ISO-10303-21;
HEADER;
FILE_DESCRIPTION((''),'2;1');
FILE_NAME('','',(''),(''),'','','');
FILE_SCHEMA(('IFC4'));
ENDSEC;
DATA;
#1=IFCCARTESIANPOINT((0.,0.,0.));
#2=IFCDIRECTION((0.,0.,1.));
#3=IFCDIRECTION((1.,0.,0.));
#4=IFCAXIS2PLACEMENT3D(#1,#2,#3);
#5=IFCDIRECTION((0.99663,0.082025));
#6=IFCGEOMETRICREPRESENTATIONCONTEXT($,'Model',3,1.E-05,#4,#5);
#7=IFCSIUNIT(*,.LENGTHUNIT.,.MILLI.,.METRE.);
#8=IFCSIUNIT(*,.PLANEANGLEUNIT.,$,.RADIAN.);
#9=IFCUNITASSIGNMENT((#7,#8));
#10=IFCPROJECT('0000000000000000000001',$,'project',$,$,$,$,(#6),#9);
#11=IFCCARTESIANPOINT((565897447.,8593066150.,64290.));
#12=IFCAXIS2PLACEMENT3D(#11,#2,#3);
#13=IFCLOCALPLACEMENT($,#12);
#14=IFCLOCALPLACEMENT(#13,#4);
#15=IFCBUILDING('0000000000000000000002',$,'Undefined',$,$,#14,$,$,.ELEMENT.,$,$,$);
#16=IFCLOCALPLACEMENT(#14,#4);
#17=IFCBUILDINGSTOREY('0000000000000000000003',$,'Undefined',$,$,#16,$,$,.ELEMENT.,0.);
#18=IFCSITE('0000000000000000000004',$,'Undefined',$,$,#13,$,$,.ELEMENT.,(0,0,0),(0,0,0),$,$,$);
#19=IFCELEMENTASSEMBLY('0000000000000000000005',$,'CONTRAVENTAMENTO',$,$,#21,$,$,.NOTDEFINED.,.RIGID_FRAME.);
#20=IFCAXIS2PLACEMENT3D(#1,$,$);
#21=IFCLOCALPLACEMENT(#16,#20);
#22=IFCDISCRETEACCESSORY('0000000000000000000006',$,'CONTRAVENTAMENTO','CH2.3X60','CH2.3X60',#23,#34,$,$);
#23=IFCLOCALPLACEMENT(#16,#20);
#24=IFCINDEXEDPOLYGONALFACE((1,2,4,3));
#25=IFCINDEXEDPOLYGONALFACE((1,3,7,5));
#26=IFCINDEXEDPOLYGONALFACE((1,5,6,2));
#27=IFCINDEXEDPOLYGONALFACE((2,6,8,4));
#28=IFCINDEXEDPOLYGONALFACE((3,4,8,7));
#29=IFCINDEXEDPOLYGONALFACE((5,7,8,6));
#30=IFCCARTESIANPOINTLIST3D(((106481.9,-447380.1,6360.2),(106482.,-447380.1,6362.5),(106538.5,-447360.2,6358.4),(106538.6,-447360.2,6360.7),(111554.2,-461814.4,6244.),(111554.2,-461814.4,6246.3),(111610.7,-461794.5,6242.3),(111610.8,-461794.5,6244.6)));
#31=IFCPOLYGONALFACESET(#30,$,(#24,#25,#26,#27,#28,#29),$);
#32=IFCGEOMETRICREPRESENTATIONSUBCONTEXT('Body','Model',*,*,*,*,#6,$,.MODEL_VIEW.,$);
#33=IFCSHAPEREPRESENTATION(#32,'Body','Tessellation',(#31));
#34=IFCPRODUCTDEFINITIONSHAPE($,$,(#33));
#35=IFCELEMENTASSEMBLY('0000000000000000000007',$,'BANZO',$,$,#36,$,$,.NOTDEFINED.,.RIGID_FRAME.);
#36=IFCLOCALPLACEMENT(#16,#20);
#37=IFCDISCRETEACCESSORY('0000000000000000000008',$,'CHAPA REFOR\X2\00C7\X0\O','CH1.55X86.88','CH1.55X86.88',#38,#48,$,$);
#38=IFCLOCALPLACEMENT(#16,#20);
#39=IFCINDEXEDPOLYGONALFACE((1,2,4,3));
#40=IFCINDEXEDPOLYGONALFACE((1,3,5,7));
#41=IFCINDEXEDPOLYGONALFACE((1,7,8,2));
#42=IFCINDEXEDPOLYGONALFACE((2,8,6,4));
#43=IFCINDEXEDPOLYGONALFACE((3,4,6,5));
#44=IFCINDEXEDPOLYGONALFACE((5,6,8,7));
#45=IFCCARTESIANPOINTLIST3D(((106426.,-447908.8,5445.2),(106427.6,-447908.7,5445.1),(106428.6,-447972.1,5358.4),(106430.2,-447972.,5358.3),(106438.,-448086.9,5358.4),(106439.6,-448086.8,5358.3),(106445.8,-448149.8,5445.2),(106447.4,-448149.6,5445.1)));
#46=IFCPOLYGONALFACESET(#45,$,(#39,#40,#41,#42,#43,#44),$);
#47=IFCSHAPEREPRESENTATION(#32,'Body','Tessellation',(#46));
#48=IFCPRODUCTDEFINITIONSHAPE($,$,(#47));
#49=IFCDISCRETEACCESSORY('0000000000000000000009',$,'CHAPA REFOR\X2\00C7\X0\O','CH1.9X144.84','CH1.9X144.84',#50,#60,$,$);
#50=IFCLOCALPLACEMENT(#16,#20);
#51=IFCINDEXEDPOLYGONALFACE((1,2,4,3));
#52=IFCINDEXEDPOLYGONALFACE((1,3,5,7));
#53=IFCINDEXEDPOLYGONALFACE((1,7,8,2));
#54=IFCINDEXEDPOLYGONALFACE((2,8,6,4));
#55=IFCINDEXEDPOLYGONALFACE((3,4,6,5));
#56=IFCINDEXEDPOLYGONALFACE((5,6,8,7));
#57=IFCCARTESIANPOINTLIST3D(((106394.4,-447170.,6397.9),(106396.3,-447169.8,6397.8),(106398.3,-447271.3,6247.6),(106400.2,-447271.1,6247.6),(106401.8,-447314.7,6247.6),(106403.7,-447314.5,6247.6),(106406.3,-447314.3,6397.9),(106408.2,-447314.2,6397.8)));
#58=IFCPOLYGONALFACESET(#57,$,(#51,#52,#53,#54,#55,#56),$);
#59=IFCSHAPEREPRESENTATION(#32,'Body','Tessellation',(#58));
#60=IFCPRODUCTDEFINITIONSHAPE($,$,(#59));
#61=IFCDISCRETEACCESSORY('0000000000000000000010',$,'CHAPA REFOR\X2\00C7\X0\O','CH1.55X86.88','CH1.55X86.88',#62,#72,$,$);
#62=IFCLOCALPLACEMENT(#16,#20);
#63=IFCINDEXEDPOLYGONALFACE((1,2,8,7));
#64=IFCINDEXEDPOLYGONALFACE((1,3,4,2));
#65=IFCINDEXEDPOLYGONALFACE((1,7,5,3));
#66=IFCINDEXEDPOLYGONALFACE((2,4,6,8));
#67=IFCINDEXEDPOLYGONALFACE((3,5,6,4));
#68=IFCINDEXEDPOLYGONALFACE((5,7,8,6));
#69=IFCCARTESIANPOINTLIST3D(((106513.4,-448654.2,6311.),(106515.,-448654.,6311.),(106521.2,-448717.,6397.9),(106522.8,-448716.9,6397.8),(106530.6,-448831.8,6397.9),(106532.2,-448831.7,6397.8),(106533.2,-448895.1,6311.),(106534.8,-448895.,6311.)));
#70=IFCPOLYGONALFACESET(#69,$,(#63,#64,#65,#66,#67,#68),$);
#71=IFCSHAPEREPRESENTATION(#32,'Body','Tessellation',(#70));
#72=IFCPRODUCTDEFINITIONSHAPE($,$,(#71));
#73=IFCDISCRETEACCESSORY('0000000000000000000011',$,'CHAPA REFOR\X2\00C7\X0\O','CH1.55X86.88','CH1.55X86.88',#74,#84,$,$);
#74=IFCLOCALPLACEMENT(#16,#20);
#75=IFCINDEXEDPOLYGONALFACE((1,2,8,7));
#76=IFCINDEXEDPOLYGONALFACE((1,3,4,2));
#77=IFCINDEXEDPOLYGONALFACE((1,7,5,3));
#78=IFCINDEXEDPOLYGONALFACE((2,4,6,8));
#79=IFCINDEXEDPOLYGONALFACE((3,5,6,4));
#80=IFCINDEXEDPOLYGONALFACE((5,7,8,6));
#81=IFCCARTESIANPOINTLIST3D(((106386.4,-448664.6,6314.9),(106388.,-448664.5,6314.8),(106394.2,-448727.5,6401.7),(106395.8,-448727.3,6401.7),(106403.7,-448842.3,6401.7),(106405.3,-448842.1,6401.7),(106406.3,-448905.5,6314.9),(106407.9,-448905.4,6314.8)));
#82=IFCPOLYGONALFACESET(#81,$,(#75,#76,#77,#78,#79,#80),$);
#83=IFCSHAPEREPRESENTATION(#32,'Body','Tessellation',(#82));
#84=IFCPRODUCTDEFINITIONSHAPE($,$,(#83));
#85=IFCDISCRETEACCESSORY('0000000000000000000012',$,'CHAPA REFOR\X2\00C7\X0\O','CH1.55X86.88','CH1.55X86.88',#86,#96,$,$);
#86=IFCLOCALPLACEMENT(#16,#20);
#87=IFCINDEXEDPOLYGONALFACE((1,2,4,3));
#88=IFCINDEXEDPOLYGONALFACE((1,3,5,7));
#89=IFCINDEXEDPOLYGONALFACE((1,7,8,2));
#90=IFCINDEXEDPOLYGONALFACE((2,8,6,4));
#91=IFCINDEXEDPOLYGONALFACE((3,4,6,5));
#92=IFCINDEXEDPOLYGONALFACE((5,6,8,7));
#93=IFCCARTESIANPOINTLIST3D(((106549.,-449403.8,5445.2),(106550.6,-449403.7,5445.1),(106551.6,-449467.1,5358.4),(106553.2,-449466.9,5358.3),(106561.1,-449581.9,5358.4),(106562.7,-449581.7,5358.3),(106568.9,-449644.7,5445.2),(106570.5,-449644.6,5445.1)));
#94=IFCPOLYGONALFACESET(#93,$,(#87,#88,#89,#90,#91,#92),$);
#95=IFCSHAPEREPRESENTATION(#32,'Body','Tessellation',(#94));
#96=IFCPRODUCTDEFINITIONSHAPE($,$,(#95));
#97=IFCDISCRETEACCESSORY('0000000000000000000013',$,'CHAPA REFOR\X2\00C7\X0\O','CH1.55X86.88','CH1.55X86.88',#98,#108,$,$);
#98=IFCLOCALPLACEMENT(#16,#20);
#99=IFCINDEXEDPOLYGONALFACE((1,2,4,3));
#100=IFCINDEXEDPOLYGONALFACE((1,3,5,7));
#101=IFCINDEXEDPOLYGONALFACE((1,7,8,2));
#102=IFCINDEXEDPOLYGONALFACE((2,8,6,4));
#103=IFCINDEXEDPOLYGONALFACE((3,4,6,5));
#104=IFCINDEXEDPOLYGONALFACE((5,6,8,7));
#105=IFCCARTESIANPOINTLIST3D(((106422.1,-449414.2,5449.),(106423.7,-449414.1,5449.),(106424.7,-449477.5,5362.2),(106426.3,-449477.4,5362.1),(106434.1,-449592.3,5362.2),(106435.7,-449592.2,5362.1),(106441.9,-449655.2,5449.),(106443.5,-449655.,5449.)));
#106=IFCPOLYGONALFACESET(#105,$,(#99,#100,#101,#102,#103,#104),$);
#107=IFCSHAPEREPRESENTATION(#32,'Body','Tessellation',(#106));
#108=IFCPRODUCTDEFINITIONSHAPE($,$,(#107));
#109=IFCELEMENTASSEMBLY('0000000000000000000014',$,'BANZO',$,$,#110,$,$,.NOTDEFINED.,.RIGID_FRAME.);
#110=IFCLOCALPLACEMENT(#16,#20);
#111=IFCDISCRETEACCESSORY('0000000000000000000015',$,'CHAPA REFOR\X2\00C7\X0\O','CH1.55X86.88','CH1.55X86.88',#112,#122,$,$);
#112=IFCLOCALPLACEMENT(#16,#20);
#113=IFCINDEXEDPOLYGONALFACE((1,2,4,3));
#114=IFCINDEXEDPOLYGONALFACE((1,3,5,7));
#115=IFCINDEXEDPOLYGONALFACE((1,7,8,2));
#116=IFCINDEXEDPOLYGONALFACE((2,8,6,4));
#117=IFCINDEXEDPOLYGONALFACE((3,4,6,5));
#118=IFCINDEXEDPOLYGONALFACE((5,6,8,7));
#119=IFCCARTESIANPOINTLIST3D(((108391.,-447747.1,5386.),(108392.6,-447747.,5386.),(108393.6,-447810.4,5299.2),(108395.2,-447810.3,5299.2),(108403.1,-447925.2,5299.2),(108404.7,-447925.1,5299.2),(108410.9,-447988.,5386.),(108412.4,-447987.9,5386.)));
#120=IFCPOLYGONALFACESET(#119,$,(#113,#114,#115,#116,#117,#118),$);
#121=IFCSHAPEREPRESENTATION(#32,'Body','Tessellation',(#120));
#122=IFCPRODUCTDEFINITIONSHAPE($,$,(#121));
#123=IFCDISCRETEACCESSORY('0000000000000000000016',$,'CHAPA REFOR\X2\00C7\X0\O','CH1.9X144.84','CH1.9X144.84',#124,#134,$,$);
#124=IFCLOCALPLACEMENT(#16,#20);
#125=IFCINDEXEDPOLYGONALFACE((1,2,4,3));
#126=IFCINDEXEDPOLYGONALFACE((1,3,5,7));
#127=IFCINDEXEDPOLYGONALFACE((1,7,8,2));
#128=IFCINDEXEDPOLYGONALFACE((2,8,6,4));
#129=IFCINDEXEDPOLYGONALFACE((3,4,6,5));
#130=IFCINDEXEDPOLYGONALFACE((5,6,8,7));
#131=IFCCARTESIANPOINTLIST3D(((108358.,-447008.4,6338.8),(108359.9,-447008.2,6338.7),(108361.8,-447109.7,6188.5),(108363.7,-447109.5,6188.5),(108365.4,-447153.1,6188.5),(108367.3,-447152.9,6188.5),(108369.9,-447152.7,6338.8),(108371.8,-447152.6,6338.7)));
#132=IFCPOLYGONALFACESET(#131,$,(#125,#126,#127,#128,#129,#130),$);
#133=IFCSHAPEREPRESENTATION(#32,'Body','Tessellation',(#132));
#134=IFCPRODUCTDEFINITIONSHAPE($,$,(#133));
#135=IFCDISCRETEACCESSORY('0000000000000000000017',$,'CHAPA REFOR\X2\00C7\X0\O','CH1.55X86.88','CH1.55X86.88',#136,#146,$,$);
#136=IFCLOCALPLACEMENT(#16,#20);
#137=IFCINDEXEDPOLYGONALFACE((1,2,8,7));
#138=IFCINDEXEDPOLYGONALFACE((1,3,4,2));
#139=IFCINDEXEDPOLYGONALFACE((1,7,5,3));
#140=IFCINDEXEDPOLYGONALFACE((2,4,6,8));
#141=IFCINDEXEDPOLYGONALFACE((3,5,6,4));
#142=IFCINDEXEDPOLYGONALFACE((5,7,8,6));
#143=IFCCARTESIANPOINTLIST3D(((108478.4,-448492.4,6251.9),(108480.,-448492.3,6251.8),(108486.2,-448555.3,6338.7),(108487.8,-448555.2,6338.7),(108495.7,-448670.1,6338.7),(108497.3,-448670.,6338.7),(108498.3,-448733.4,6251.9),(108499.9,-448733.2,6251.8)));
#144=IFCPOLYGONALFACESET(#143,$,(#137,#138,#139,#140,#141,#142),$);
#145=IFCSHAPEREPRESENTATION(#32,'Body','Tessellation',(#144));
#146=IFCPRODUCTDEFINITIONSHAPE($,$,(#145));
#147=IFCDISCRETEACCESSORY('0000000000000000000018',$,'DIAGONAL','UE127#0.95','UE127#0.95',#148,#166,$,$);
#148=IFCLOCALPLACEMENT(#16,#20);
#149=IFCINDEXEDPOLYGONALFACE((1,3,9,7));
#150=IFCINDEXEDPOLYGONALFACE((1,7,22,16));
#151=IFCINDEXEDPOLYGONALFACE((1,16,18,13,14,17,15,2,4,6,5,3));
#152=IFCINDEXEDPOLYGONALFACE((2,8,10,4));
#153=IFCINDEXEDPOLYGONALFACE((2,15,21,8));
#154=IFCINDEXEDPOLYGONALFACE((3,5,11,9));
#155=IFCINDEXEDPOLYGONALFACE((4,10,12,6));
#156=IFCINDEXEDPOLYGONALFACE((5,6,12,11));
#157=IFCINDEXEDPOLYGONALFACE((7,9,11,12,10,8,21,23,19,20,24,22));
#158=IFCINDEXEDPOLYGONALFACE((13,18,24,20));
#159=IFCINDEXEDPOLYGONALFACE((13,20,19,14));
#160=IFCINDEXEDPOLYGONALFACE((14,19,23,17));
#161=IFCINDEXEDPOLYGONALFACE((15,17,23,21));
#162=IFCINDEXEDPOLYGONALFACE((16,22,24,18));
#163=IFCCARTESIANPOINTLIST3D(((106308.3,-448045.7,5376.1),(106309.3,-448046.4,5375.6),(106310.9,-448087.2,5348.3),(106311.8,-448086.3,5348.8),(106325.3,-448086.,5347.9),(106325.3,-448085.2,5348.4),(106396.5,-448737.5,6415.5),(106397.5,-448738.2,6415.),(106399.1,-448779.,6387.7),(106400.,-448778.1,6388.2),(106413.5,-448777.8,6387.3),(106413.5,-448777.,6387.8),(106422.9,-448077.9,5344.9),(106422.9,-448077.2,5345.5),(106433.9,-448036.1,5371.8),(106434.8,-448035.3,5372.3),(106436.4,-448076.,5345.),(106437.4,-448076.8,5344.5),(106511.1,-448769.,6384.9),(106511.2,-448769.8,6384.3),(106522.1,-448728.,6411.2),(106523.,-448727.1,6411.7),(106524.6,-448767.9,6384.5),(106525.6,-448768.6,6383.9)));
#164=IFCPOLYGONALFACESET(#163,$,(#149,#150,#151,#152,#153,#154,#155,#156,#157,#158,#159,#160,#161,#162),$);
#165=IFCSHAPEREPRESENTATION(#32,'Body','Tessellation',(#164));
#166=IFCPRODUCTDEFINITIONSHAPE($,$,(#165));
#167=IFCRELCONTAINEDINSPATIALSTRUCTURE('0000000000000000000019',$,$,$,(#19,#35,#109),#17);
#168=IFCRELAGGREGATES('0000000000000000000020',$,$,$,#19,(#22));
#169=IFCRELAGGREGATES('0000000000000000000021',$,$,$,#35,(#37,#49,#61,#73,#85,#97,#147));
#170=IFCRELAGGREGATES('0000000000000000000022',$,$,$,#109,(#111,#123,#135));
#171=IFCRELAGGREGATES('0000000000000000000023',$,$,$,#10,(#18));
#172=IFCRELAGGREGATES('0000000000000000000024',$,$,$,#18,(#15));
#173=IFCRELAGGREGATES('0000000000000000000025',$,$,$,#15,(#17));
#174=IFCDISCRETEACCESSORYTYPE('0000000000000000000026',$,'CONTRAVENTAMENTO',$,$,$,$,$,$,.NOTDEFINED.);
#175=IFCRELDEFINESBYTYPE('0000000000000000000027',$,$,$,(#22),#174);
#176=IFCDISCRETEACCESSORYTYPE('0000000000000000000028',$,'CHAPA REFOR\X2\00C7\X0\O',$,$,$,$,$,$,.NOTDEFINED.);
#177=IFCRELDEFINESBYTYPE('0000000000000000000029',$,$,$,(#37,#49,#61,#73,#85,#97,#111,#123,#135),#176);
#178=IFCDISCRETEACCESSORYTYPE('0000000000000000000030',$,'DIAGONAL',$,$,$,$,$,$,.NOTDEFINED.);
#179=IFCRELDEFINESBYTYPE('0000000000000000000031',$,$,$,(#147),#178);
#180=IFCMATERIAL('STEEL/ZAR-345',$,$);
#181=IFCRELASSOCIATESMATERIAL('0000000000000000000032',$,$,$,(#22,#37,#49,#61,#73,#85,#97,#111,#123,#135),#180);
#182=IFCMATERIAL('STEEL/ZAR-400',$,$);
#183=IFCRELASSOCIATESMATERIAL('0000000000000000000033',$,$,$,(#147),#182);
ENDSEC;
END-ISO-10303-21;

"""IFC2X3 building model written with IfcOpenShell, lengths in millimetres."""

from ifc_helpers import new_model, si_unit, direction, frame, frame_2d, origin_with_axes, place, context, subcontext, project, spatial, polyline, c_section, outline, extrude, material, type_object, element, aggregate, save


model = new_model("IFC2X3")

# Units and contexts
model_context = context("Model", 3, precision=1e-05, world=origin_with_axes(), true_north=direction((0.99663, 0.082025)))
body_context = subcontext(model_context, "Body", "Model", "MODEL_VIEW")
ifc_project = project(units=[si_unit("LENGTHUNIT", "METRE", prefix="MILLI"), si_unit("PLANEANGLEUNIT", "RADIAN")], contexts=[model_context])

# Site, building, storey
site_placement = place(None, frame((565897447.0, 8593066150.0, 64290.0), z_axis=(0.0, 0.0, 1.0), x_axis=(1.0, 0.0, 0.0)))
site = spatial("IfcSite", under=ifc_project, at=site_placement, Name="Undefined", CompositionType="ELEMENT", RefLatitude=(0, 0, 0), RefLongitude=(0, 0, 0))
building_placement = place(site_placement, origin_with_axes())
building = spatial("IfcBuilding", under=site, at=building_placement, Name="Undefined", CompositionType="ELEMENT")
storey_placement = place(building_placement, origin_with_axes())
storey = spatial("IfcBuildingStorey", under=building, at=storey_placement, Name="Undefined", CompositionType="ELEMENT", Elevation=0.0)

# Shared definitions
ifc_material_1 = material(Name="STEEL/ZAR-400")

# Element assemblies, discrete accessories
assembly_1_placement = place(storey_placement, origin_with_axes())
assembly_1 = element("IfcElementAssembly", 1, at=assembly_1_placement, inside=storey, Name="CONTRAVENTAMENTO", AssemblyPlace="NOTDEFINED", PredefinedType="RIGID_FRAME")
discrete_accessory_type_1 = type_object("IfcDiscreteAccessoryType", Name="CONTRAVENTAMENTO")
ifc_material_2 = material(Name="STEEL/ZAR-345")
discrete_accessory_1_placement = place(assembly_1_placement, frame((106510.2, -447370.2, 6360.4), z_axis=(0.029885, 0.00246, 0.99955), x_axis=(0.331521, -0.943417, -0.007591)))
discrete_accessory_1 = element("IfcDiscreteAccessory", 2, at=discrete_accessory_1_placement, type_object=discrete_accessory_type_1, material=ifc_material_2, Name="CONTRAVENTAMENTO", Description="CH2.3X60", ObjectType="CH2.3X60", context=body_context, shape_type="SweptSolid", body=[
    extrude(outline(polyline([(0.0, 30.0), (15300.0, 30.0), (15300.0, -30.0), (0.0, -30.0), (0.0, 30.0)])), frame((0.0, 0.0, -1.2), z_axis=(0.0, 0.0, 1.0), x_axis=(1.0, 0.0, 0.0)), (0.0, 0.0, 1.0), 2.3),
])
aggregate(assembly_1, [discrete_accessory_1])
assembly_2_placement = place(storey_placement, origin_with_axes())
assembly_2 = element("IfcElementAssembly", 3, at=assembly_2_placement, inside=storey, Name="BANZO", AssemblyPlace="NOTDEFINED", PredefinedType="RIGID_FRAME")
discrete_accessory_type_2 = type_object("IfcDiscreteAccessoryType", Name="CHAPA REFORÇO")
discrete_accessory_2_placement = place(assembly_2_placement, frame((106426.8, -447908.8, 5445.2), z_axis=(0.996182, 0.081989, -0.029987), x_axis=(0.082025, -0.99663, 0.0)))
discrete_accessory_2 = element("IfcDiscreteAccessory", 4, at=discrete_accessory_2_placement, type_object=discrete_accessory_type_2, material=ifc_material_2, Name="CHAPA REFORÇO", Description="CH1.55X86.88", ObjectType="CH1.55X86.88", context=body_context, shape_type="SweptSolid", body=[
    extrude(outline(polyline([(0.0, 0.0), (241.7, 0.0), (178.5, 86.9), (63.3, 86.9), (0.0, 0.0)])), frame((0.0, 0.0, -0.8), z_axis=(0.0, 0.0, 1.0), x_axis=(1.0, 0.0, 0.0)), (0.0, 0.0, 1.0), 1.6),
])
discrete_accessory_3_placement = place(assembly_2_placement, frame((106407.3, -447314.2, 6397.8), z_axis=(-0.996182, -0.081989, 0.029987), x_axis=(-0.082025, 0.99663, 0.0)))
discrete_accessory_3 = element("IfcDiscreteAccessory", 5, at=discrete_accessory_3_placement, type_object=discrete_accessory_type_2, material=ifc_material_2, Name="CHAPA REFORÇO", Description="CH1.9X144.84", ObjectType="CH1.9X144.84", context=body_context, shape_type="SweptSolid", body=[
    extrude(outline(polyline([(0.0, 0.0), (144.8, 0.0), (43.5, 150.3), (0.0, 150.3), (0.0, 0.0)])), frame((0.0, 0.0, -0.9), z_axis=(0.0, 0.0, 1.0), x_axis=(1.0, 0.0, 0.0)), (0.0, 0.0, 1.0), 1.9),
])
discrete_accessory_4_placement = place(assembly_2_placement, frame((106534.0, -448895.0, 6311.0), z_axis=(0.996182, 0.081989, -0.029987), x_axis=(-0.082025, 0.99663, 0.0)))
discrete_accessory_4 = element("IfcDiscreteAccessory", 6, at=discrete_accessory_4_placement, type_object=discrete_accessory_type_2, material=ifc_material_2, Name="CHAPA REFORÇO", Description="CH1.55X86.88", ObjectType="CH1.55X86.88", context=body_context, shape_type="SweptSolid", body=[
    extrude(outline(polyline([(0.0, 0.0), (241.7, 0.0), (178.5, 86.9), (63.3, 86.9), (0.0, 0.0)])), frame((0.0, 0.0, -0.8), z_axis=(0.0, 0.0, 1.0), x_axis=(1.0, 0.0, 0.0)), (0.0, 0.0, 1.0), 1.6),
])
discrete_accessory_5_placement = place(assembly_2_placement, frame((106407.1, -448905.5, 6314.8), z_axis=(0.996182, 0.081989, -0.029987), x_axis=(-0.082025, 0.99663, 0.0)))
discrete_accessory_5 = element("IfcDiscreteAccessory", 7, at=discrete_accessory_5_placement, type_object=discrete_accessory_type_2, material=ifc_material_2, Name="CHAPA REFORÇO", Description="CH1.55X86.88", ObjectType="CH1.55X86.88", context=body_context, shape_type="SweptSolid", body=[
    extrude(outline(polyline([(0.0, 0.0), (241.7, 0.0), (178.5, 86.9), (63.3, 86.9), (0.0, 0.0)])), frame((0.0, 0.0, -0.8), z_axis=(0.0, 0.0, 1.0), x_axis=(1.0, 0.0, 0.0)), (0.0, 0.0, 1.0), 1.6),
])
discrete_accessory_6_placement = place(assembly_2_placement, frame((106549.8, -449403.7, 5445.2), z_axis=(0.996182, 0.081989, -0.029987), x_axis=(0.082025, -0.99663, 0.0)))
discrete_accessory_6 = element("IfcDiscreteAccessory", 8, at=discrete_accessory_6_placement, type_object=discrete_accessory_type_2, material=ifc_material_2, Name="CHAPA REFORÇO", Description="CH1.55X86.88", ObjectType="CH1.55X86.88", context=body_context, shape_type="SweptSolid", body=[
    extrude(outline(polyline([(0.0, 0.0), (241.7, 0.0), (178.5, 86.9), (63.3, 86.9), (0.0, 0.0)])), frame((0.0, 0.0, -0.8), z_axis=(0.0, 0.0, 1.0), x_axis=(1.0, 0.0, 0.0)), (0.0, 0.0, 1.0), 1.6),
])
discrete_accessory_7_placement = place(assembly_2_placement, frame((106422.9, -449414.2, 5449.0), z_axis=(0.996182, 0.081989, -0.029987), x_axis=(0.082025, -0.99663, 0.0)))
discrete_accessory_7 = element("IfcDiscreteAccessory", 9, at=discrete_accessory_7_placement, type_object=discrete_accessory_type_2, material=ifc_material_2, Name="CHAPA REFORÇO", Description="CH1.55X86.88", ObjectType="CH1.55X86.88", context=body_context, shape_type="SweptSolid", body=[
    extrude(outline(polyline([(0.0, 0.0), (241.7, 0.0), (178.5, 86.9), (63.3, 86.9), (0.0, 0.0)])), frame((0.0, 0.0, -0.8), z_axis=(0.0, 0.0, 1.0), x_axis=(1.0, 0.0, 0.0)), (0.0, 0.0, 1.0), 1.6),
])
assembly_3_placement = place(storey_placement, origin_with_axes())
assembly_3 = element("IfcElementAssembly", 10, at=assembly_3_placement, inside=storey, Name="BANZO", AssemblyPlace="NOTDEFINED", PredefinedType="RIGID_FRAME")
discrete_accessory_8_placement = place(assembly_3_placement, frame((108391.8, -447747.0, 5386.0), z_axis=(0.996182, 0.081989, -0.029987), x_axis=(0.082025, -0.99663, 0.0)))
discrete_accessory_8 = element("IfcDiscreteAccessory", 11, at=discrete_accessory_8_placement, type_object=discrete_accessory_type_2, material=ifc_material_2, Name="CHAPA REFORÇO", Description="CH1.55X86.88", ObjectType="CH1.55X86.88", context=body_context, shape_type="SweptSolid", body=[
    extrude(outline(polyline([(0.0, 0.0), (241.7, 0.0), (178.5, 86.9), (63.3, 86.9), (0.0, 0.0)])), frame((0.0, 0.0, -0.8), z_axis=(0.0, 0.0, 1.0), x_axis=(1.0, 0.0, 0.0)), (0.0, 0.0, 1.0), 1.6),
])
discrete_accessory_9_placement = place(assembly_3_placement, frame((108370.8, -447152.6, 6338.7), z_axis=(-0.996182, -0.081989, 0.029987), x_axis=(-0.082025, 0.99663, 0.0)))
discrete_accessory_9 = element("IfcDiscreteAccessory", 12, at=discrete_accessory_9_placement, type_object=discrete_accessory_type_2, material=ifc_material_2, Name="CHAPA REFORÇO", Description="CH1.9X144.84", ObjectType="CH1.9X144.84", context=body_context, shape_type="SweptSolid", body=[
    extrude(outline(polyline([(0.0, 0.0), (144.8, 0.0), (43.5, 150.3), (0.0, 150.3), (0.0, 0.0)])), frame((0.0, 0.0, -0.9), z_axis=(0.0, 0.0, 1.0), x_axis=(1.0, 0.0, 0.0)), (0.0, 0.0, 1.0), 1.9),
])
discrete_accessory_10_placement = place(assembly_3_placement, frame((108499.1, -448733.3, 6251.9), z_axis=(0.996182, 0.081989, -0.029987), x_axis=(-0.082025, 0.99663, 0.0)))
discrete_accessory_10 = element("IfcDiscreteAccessory", 13, at=discrete_accessory_10_placement, type_object=discrete_accessory_type_2, material=ifc_material_2, Name="CHAPA REFORÇO", Description="CH1.55X86.88", ObjectType="CH1.55X86.88", context=body_context, shape_type="SweptSolid", body=[
    extrude(outline(polyline([(0.0, 0.0), (241.7, 0.0), (178.5, 86.9), (63.3, 86.9), (0.0, 0.0)])), frame((0.0, 0.0, -0.8), z_axis=(0.0, 0.0, 1.0), x_axis=(1.0, 0.0, 0.0)), (0.0, 0.0, 1.0), 1.6),
])

# Discrete accessory
discrete_accessory_type_3 = type_object("IfcDiscreteAccessoryType", Name="DIAGONAL")
discrete_accessory_11_placement = place(assembly_2_placement, frame((106372.8, -448061.2, 5360.3), z_axis=(-0.996182, -0.081989, 0.029987), x_axis=(0.070485, -0.552697, 0.830396)))
discrete_accessory_11 = element("IfcDiscreteAccessory", 14, at=discrete_accessory_11_placement, type_object=discrete_accessory_type_3, material=ifc_material_1, Name="DIAGONAL", Description="UE127#0.95", ObjectType="UE127#0.95", context=body_context, shape_type="SweptSolid", body=[
    extrude(c_section(Depth=127.0, Width=50.0, WallThickness=0.9, Girth=14.5, at=frame_2d((0.0, 0.0), x_axis=(1.0, 0.0))), frame((1251.7, 0.0, 0.0), z_axis=(-1.0, 0.0, 0.0), x_axis=(0.0, -1.0, 0.0)), (0.0, 0.0, 1.0), 1251.7),
])
aggregate(assembly_2, [discrete_accessory_2, discrete_accessory_3, discrete_accessory_4, discrete_accessory_5, discrete_accessory_6, discrete_accessory_7, discrete_accessory_11])
aggregate(assembly_3, [discrete_accessory_8, discrete_accessory_9, discrete_accessory_10])

save(model, "model.ifc")
